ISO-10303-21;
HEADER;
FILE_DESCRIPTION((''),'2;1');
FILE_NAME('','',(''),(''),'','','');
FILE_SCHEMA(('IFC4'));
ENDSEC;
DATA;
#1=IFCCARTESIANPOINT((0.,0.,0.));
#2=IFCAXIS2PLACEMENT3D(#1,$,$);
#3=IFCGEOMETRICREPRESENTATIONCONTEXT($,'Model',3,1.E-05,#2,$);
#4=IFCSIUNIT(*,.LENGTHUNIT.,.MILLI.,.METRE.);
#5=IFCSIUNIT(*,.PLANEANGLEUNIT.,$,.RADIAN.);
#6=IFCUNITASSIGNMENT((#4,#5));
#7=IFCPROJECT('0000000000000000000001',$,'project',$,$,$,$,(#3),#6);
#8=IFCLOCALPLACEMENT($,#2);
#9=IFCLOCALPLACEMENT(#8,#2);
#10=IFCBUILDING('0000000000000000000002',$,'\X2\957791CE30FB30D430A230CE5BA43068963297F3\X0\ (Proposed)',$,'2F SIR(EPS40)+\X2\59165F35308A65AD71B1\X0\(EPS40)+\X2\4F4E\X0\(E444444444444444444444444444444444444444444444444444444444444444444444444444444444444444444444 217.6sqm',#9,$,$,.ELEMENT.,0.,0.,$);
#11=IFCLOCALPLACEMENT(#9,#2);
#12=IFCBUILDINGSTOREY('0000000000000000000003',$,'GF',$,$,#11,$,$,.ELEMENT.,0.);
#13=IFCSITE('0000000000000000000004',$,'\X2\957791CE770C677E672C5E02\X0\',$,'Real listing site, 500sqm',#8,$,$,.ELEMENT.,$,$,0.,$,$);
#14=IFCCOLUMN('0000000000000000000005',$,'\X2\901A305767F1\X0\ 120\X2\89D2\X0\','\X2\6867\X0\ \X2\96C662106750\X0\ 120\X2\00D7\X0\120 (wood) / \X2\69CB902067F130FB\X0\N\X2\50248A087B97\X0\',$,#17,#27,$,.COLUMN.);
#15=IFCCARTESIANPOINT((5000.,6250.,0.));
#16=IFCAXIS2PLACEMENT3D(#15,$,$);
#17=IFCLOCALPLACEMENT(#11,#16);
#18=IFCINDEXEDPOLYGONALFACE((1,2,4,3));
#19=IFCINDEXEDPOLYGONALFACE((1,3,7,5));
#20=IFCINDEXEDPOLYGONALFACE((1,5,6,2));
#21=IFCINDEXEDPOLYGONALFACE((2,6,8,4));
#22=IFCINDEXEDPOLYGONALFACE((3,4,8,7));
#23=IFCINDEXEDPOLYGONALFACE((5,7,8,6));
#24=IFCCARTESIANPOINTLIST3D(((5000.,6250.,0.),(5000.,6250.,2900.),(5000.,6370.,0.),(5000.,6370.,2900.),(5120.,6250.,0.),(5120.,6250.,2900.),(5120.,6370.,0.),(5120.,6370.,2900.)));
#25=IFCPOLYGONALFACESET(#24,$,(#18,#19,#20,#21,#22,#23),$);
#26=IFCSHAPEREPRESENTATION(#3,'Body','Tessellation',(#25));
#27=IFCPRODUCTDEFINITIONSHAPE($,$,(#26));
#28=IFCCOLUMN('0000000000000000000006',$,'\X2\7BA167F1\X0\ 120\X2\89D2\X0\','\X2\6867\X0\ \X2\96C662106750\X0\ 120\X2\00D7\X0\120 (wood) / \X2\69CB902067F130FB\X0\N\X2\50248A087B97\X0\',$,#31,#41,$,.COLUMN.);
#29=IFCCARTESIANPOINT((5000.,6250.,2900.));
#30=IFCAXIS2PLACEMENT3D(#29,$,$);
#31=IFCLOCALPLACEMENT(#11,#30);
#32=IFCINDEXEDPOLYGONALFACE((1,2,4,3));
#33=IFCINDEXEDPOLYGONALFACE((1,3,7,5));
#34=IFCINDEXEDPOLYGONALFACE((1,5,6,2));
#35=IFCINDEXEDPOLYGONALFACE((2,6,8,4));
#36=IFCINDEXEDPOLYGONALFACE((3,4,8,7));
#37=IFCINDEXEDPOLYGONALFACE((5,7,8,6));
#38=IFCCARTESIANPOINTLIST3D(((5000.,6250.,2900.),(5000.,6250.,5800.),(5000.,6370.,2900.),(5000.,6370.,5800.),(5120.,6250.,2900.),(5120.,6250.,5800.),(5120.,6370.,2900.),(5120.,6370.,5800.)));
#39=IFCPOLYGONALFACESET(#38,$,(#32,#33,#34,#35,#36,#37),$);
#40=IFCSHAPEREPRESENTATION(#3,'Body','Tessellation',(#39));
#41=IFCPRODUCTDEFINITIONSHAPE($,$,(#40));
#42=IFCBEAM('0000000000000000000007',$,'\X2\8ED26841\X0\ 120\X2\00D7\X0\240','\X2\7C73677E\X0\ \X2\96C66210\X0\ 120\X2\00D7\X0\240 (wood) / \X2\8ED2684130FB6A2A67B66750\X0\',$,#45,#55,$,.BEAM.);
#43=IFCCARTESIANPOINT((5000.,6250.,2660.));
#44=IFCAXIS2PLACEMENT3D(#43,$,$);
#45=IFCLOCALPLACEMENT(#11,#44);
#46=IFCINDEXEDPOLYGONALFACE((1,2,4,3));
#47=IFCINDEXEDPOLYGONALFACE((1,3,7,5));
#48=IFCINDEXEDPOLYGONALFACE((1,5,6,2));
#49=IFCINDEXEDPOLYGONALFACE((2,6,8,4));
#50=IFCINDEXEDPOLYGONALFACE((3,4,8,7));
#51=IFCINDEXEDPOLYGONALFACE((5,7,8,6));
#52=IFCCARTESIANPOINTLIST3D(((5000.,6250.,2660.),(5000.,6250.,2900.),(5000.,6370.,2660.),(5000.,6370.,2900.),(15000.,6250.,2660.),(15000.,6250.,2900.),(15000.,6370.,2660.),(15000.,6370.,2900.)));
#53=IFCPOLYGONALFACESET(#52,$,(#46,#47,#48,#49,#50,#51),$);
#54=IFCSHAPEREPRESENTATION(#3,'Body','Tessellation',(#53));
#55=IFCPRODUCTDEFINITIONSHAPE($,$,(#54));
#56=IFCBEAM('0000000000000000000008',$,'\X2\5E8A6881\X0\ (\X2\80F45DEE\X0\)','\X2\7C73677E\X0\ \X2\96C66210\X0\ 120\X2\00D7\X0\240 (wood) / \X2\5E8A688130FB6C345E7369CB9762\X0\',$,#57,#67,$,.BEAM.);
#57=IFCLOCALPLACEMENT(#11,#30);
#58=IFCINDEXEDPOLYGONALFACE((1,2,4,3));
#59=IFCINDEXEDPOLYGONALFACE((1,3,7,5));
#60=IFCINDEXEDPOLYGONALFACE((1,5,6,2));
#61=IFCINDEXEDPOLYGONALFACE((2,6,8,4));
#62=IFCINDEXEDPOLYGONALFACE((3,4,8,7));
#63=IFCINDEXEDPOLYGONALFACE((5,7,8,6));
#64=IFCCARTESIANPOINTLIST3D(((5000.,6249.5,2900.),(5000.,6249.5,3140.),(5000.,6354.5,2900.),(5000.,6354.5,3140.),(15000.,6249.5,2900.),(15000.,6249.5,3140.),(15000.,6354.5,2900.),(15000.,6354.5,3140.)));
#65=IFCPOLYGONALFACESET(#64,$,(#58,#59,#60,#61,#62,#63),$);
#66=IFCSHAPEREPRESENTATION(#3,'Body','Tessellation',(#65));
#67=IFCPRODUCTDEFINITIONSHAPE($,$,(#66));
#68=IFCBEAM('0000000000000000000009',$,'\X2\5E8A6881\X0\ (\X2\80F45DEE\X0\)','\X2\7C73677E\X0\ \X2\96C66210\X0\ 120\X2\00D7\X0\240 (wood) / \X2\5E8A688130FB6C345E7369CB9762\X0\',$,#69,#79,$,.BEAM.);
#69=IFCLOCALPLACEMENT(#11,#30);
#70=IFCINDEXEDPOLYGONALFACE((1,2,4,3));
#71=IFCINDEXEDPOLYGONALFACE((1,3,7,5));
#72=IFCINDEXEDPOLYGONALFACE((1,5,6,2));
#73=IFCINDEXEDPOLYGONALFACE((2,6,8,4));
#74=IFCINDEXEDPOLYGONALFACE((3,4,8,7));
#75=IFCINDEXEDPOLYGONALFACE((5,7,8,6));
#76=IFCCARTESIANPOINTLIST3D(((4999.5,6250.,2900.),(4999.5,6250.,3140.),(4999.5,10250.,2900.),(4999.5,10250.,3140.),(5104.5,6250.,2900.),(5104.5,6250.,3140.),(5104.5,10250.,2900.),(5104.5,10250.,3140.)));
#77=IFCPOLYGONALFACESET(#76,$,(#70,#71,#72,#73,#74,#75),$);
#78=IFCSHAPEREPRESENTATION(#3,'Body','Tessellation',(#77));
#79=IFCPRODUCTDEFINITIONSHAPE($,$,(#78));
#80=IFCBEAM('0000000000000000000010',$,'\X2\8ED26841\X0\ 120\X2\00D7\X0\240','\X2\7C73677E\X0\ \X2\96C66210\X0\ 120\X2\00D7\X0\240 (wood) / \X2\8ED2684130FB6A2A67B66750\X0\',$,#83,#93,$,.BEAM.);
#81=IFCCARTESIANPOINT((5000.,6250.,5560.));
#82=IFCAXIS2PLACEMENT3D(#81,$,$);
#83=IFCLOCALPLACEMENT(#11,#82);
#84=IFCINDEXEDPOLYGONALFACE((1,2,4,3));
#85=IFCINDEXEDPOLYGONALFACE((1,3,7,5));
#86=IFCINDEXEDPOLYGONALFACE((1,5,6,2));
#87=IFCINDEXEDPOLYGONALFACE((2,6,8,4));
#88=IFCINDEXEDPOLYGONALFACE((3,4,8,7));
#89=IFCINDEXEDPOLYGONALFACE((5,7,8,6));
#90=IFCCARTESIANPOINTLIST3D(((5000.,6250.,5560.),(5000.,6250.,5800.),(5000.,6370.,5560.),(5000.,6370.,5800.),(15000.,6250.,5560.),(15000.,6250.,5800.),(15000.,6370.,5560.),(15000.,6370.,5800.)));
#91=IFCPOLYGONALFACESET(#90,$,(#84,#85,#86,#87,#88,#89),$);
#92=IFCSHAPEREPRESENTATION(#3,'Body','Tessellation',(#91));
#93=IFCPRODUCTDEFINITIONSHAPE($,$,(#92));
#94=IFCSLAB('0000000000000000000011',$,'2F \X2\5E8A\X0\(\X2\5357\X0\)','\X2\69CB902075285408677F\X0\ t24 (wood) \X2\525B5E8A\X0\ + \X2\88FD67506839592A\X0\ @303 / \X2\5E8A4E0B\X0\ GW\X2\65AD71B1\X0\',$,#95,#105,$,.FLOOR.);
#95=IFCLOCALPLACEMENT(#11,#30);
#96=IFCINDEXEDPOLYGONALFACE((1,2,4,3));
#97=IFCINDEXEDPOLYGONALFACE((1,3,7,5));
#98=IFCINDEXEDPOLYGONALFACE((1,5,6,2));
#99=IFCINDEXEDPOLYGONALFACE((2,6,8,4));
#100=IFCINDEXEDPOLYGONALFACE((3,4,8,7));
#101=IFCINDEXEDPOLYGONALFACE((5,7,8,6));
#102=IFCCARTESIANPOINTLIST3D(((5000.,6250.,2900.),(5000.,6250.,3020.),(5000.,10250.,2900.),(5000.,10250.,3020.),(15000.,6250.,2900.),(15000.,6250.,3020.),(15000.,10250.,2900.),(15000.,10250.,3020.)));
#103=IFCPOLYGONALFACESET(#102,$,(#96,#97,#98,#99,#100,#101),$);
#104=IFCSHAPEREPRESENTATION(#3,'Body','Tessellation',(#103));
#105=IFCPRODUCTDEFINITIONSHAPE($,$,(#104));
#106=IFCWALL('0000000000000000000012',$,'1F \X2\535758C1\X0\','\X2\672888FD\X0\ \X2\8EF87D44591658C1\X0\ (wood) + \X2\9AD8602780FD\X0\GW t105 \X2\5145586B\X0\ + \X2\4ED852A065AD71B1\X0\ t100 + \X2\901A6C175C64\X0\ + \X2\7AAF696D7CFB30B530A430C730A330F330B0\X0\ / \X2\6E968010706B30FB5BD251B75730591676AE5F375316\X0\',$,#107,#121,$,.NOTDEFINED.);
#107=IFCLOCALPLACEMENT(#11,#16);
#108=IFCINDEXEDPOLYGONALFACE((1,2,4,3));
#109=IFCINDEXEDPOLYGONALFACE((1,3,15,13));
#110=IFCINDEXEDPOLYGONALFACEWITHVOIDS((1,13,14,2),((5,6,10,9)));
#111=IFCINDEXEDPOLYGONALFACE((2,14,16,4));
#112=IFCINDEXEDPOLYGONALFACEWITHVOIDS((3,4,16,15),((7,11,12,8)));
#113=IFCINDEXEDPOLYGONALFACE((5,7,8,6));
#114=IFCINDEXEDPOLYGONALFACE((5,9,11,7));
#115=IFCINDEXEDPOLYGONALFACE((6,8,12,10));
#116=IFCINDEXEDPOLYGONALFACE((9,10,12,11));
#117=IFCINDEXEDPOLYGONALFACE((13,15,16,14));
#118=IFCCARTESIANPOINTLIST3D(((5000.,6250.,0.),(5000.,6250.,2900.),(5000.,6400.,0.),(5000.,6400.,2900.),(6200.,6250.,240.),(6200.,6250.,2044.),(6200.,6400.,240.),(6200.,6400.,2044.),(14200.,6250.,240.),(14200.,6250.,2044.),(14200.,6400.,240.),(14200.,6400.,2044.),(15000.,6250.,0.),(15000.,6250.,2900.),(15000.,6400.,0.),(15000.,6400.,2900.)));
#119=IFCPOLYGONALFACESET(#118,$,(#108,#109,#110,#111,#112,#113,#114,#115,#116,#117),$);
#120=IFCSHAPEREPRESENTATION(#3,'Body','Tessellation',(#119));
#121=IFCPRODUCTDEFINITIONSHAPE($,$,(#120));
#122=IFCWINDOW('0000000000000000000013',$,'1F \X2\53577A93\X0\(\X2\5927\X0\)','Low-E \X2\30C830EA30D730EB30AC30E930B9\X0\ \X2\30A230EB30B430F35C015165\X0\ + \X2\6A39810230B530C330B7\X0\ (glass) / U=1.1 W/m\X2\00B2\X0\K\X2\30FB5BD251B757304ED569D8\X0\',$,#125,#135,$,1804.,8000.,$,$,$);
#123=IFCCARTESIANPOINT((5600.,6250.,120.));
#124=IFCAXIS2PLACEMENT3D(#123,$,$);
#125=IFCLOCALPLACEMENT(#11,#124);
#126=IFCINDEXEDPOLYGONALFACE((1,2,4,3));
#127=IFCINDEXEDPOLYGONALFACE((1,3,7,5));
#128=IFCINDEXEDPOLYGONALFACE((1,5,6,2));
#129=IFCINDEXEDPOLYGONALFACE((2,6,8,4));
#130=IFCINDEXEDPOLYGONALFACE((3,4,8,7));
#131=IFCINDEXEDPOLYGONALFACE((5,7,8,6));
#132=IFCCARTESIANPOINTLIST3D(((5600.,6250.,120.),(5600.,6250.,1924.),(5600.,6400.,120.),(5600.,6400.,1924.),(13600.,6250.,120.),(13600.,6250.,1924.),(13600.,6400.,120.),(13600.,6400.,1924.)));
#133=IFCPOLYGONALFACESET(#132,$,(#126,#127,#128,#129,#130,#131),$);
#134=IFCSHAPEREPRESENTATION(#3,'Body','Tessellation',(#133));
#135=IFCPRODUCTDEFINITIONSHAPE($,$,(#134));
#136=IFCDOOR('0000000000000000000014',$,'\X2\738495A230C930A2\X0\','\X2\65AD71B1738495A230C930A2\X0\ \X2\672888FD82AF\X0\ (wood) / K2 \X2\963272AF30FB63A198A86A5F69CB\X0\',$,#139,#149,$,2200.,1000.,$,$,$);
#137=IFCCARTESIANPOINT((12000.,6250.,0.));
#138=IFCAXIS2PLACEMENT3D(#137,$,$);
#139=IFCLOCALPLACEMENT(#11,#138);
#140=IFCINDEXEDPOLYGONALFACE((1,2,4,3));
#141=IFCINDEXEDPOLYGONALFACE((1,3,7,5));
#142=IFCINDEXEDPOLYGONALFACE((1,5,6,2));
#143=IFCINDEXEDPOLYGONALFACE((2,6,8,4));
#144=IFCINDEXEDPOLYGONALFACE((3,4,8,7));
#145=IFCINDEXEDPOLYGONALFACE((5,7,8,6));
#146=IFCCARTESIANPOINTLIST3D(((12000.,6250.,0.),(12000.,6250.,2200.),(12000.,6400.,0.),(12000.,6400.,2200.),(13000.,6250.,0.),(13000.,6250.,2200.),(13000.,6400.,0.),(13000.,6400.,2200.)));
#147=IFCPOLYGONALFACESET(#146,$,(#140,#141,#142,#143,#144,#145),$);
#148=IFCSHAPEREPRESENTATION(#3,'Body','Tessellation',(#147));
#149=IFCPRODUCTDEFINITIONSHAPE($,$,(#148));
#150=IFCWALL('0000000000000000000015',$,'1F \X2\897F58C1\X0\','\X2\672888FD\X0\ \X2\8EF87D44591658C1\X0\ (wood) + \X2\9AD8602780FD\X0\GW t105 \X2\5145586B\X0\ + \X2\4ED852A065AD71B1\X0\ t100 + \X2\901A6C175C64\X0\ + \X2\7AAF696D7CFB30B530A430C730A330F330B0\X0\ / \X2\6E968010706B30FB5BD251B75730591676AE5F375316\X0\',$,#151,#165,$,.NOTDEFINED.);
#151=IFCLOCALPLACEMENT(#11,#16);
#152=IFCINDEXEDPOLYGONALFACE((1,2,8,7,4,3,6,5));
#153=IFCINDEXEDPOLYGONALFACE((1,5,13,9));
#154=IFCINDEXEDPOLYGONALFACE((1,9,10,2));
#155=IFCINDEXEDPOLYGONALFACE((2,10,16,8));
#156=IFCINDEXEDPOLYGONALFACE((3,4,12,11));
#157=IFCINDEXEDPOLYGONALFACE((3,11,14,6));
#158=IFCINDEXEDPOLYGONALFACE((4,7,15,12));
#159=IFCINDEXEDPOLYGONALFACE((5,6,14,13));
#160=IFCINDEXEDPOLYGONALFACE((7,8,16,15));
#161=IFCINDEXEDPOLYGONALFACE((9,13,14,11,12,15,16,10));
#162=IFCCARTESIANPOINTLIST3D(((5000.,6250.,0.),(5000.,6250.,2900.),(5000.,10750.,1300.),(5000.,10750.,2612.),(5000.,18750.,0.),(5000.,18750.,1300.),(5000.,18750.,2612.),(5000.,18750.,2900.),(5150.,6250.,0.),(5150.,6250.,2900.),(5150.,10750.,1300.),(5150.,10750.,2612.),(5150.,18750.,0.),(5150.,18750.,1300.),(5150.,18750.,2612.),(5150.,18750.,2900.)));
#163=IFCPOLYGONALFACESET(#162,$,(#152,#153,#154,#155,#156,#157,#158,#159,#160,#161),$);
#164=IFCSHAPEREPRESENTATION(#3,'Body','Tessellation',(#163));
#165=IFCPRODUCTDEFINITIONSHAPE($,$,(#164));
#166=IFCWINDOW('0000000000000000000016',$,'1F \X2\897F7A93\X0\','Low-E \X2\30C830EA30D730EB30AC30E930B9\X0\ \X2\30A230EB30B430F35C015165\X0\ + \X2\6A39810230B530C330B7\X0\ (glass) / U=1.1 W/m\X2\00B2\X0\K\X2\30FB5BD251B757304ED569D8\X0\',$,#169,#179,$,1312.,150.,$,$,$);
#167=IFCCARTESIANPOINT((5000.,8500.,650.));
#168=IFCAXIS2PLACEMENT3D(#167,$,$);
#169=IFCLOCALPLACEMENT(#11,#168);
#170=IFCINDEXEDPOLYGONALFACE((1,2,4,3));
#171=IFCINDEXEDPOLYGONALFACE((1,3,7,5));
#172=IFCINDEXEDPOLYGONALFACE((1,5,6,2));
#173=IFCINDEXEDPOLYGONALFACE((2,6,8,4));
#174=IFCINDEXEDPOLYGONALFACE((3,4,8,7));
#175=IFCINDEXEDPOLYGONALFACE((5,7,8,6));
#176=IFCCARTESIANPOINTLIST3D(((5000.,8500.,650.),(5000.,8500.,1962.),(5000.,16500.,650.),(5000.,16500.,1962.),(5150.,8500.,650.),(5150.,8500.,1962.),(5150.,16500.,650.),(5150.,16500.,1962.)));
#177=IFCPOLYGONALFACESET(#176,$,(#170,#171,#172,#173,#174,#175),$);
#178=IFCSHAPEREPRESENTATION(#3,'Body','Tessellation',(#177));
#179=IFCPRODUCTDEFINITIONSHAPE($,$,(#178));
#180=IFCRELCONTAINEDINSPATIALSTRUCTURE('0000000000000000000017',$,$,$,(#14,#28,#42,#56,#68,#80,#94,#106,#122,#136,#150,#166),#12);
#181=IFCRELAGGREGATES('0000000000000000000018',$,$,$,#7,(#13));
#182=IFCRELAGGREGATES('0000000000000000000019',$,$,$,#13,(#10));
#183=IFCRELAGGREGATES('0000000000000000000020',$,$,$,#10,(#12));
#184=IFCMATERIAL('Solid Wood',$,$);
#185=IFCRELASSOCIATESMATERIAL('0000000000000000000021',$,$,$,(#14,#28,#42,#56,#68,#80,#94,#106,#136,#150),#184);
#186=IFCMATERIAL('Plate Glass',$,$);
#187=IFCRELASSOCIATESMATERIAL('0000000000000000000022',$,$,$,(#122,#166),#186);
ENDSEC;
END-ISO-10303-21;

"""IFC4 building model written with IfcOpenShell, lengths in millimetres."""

from ifc_helpers import new_model, si_unit, frame, frame_2d, origin, place, context, project, spatial, rectangle, extrude, material, element, fill, save


model = new_model("IFC4")

# Units and contexts
model_context = context("Model", 3, precision=1e-05, world=origin())
ifc_project = project(units=[si_unit("LENGTHUNIT", "METRE", prefix="MILLI"), si_unit("PLANEANGLEUNIT", "RADIAN")], contexts=[model_context])

# Site, building, storey
site_placement = place(None, origin())
site = spatial("IfcSite", under=ifc_project, at=site_placement, Name="長野県松本市", ObjectType="Real listing site, 500sqm", CompositionType="ELEMENT", RefElevation=0.0)
building_placement = place(site_placement, origin())
building = spatial("IfcBuilding", under=site, at=building_placement, Name="長野・ピアノ室と防音 (Proposed)", ObjectType="2F SIR(EPS40)+外張り断熱(EPS40)+低(E444444444444444444444444444444444444444444444444444444444444444444444444444444444444444444444 217.6sqm", CompositionType="ELEMENT", ElevationOfRefHeight=0.0, ElevationOfTerrain=0.0)
storey_placement = place(building_placement, origin())
storey = spatial("IfcBuildingStorey", under=building, at=storey_placement, Name="GF", CompositionType="ELEMENT", Elevation=0.0)

# Columns
ifc_material_1 = material(Name="Solid Wood")
column_1_placement = place(storey_placement, frame((5000.0, 6250.0, 0.0)))
element("IfcColumn", 1, at=column_1_placement, inside=storey, material=ifc_material_1, Name="通し柱 120角", Description="桧 集成材 120×120 (wood) / 構造柱・N値計算", PredefinedType="COLUMN", context=model_context, shape_type="SweptSolid", body=[
    extrude(rectangle(XDim=120.0, YDim=120.0, at=frame_2d((60.0, 60.0))), frame((5000.0, 6250.0, 0.0)), (0.0, 0.0, 1.0), 2900.0),
])
column_2_placement = place(storey_placement, frame((5000.0, 6250.0, 2900.0)))
element("IfcColumn", 2, at=column_2_placement, inside=storey, material=ifc_material_1, Name="管柱 120角", Description="桧 集成材 120×120 (wood) / 構造柱・N値計算", PredefinedType="COLUMN", context=model_context, shape_type="SweptSolid", body=[
    extrude(rectangle(XDim=120.0, YDim=120.0, at=frame_2d((60.0, 60.0))), frame((5000.0, 6250.0, 2900.0)), (0.0, 0.0, 1.0), 2900.0),
])

# Beams
beam_1_placement = place(storey_placement, frame((5000.0, 6250.0, 2660.0)))
element("IfcBeam", 3, at=beam_1_placement, inside=storey, material=ifc_material_1, Name="軒桁 120×240", Description="米松 集成 120×240 (wood) / 軒桁・横架材", PredefinedType="BEAM", context=model_context, shape_type="SweptSolid", body=[
    extrude(rectangle(XDim=10000.0, YDim=120.0, at=frame_2d((5000.0, 60.0))), frame((5000.0, 6250.0, 2660.0)), (0.0, 0.0, 1.0), 240.0),
])
beam_2_placement = place(storey_placement, frame((5000.0, 6250.0, 2900.0)))
element("IfcBeam", 4, at=beam_2_placement, inside=storey, material=ifc_material_1, Name="床梁 (胴差)", Description="米松 集成 120×240 (wood) / 床梁・水平構面", PredefinedType="BEAM", context=model_context, shape_type="SweptSolid", body=[
    extrude(rectangle(XDim=10000.0, YDim=105.0, at=frame_2d((5000.0, 52.0))), frame((5000.0, 6250.0, 2900.0)), (0.0, 0.0, 1.0), 240.0),
])
beam_3_placement = place(storey_placement, frame((5000.0, 6250.0, 2900.0)))
element("IfcBeam", 5, at=beam_3_placement, inside=storey, material=ifc_material_1, Name="床梁 (胴差)", Description="米松 集成 120×240 (wood) / 床梁・水平構面", PredefinedType="BEAM", context=model_context, shape_type="SweptSolid", body=[
    extrude(rectangle(XDim=105.0, YDim=4000.0, at=frame_2d((52.0, 2000.0))), frame((5000.0, 6250.0, 2900.0)), (0.0, 0.0, 1.0), 240.0),
])
beam_4_placement = place(storey_placement, frame((5000.0, 6250.0, 5560.0)))
element("IfcBeam", 6, at=beam_4_placement, inside=storey, material=ifc_material_1, Name="軒桁 120×240", Description="米松 集成 120×240 (wood) / 軒桁・横架材", PredefinedType="BEAM", context=model_context, shape_type="SweptSolid", body=[
    extrude(rectangle(XDim=10000.0, YDim=120.0, at=frame_2d((5000.0, 60.0))), frame((5000.0, 6250.0, 5560.0)), (0.0, 0.0, 1.0), 240.0),
])

# Slab
slab_1_placement = place(storey_placement, frame((5000.0, 6250.0, 2900.0)))
element("IfcSlab", 7, at=slab_1_placement, inside=storey, material=ifc_material_1, Name="2F 床(南)", Description="構造用合板 t24 (wood) 剛床 + 製材根太 @303 / 床下 GW断熱", PredefinedType="FLOOR", context=model_context, shape_type="SweptSolid", body=[
    extrude(rectangle(XDim=10000.0, YDim=4000.0, at=frame_2d((5000.0, 2000.0))), frame((5000.0, 6250.0, 2900.0)), (0.0, 0.0, 1.0), 120.0),
])

# Wall, openings, window, door
wall_1_placement = place(storey_placement, frame((5000.0, 6250.0, 0.0)))
wall_1 = element("IfcWall", 8, at=wall_1_placement, inside=storey, material=ifc_material_1, Name="1F 南壁", Description="木製 軸組外壁 (wood) + 高性能GW t105 充填 + 付加断熱 t100 + 通気層 + 窯業系サイディング / 準耐火・寒冷地外皮強化", PredefinedType="NOTDEFINED", context=model_context, shape_type="SweptSolid", body=[
    extrude(rectangle(XDim=10000.0, YDim=150.0, at=frame_2d((5000.0, 75.0))), frame((5000.0, 6250.0, 0.0)), (0.0, 0.0, 1.0), 2900.0),
])
opening_1_placement = place(storey_placement, frame((5600.0, 6250.0, 120.0)))
opening_1 = element("IfcOpeningElement", 9, at=opening_1_placement, cuts=wall_1, PredefinedType="NOTDEFINED", context=model_context, shape_type="SweptSolid", body=[
    extrude(rectangle(XDim=8000.0, YDim=150.0, at=frame_2d((4000.0, 75.0))), frame((5600.0, 6250.0, 120.0)), (0.0, 0.0, 1.0), 1804.0),
])
opening_2_placement = place(storey_placement, frame((12000.0, 6250.0, 0.0)))
opening_2 = element("IfcOpeningElement", 10, at=opening_2_placement, cuts=wall_1, PredefinedType="NOTDEFINED", context=model_context, shape_type="SweptSolid", body=[
    extrude(rectangle(XDim=1000.0, YDim=150.0, at=frame_2d((500.0, 75.0))), frame((12000.0, 6250.0, 0.0)), (0.0, 0.0, 1.0), 2200.0),
])
ifc_material_2 = material(Name="Plate Glass")
window_1_placement = place(storey_placement, frame((5600.0, 6250.0, 120.0)))
window_1 = element("IfcWindow", 11, at=window_1_placement, inside=storey, material=ifc_material_2, Name="1F 南窓(大)", Description="Low-E トリプルガラス アルゴン封入 + 樹脂サッシ (glass) / U=1.1 W/m²K・寒冷地仕様", OverallHeight=1804.0, OverallWidth=8000.0, context=model_context, shape_type="SweptSolid", body=[
    extrude(rectangle(XDim=8000.0, YDim=150.0, at=frame_2d((4000.0, 75.0))), frame((5600.0, 6250.0, 120.0)), (0.0, 0.0, 1.0), 1804.0),
])
fill(opening_1, window_1)
door_placement = place(storey_placement, frame((12000.0, 6250.0, 0.0)))
door = element("IfcDoor", 12, at=door_placement, inside=storey, material=ifc_material_1, Name="玄関ドア", Description="断熱玄関ドア 木製芯 (wood) / K2 防犯・採風機構", OverallHeight=2200.0, OverallWidth=1000.0, context=model_context, shape_type="SweptSolid", body=[
    extrude(rectangle(XDim=1000.0, YDim=150.0, at=frame_2d((500.0, 75.0))), frame((12000.0, 6250.0, 0.0)), (0.0, 0.0, 1.0), 2200.0),
])
fill(opening_2, door)

# Wall, opening, window
wall_2_placement = place(storey_placement, frame((5000.0, 6250.0, 0.0)))
wall_2 = element("IfcWall", 13, at=wall_2_placement, inside=storey, material=ifc_material_1, Name="1F 西壁", Description="木製 軸組外壁 (wood) + 高性能GW t105 充填 + 付加断熱 t100 + 通気層 + 窯業系サイディング / 準耐火・寒冷地外皮強化", PredefinedType="NOTDEFINED", context=model_context, shape_type="SweptSolid", body=[
    extrude(rectangle(XDim=150.0, YDim=12500.0, at=frame_2d((75.0, 6250.0))), frame((5000.0, 6250.0, 0.0)), (0.0, 0.0, 1.0), 2900.0),
])
opening_3_placement = place(storey_placement, frame((5000.0, 8500.0, 650.0)))
opening_3 = element("IfcOpeningElement", 14, at=opening_3_placement, cuts=wall_2, PredefinedType="NOTDEFINED", context=model_context, shape_type="SweptSolid", body=[
    extrude(rectangle(XDim=150.0, YDim=8000.0, at=frame_2d((75.0, 4000.0))), frame((5000.0, 8500.0, 650.0)), (0.0, 0.0, 1.0), 1312.0),
])
window_2_placement = place(storey_placement, frame((5000.0, 8500.0, 650.0)))
window_2 = element("IfcWindow", 15, at=window_2_placement, inside=storey, material=ifc_material_2, Name="1F 西窓", Description="Low-E トリプルガラス アルゴン封入 + 樹脂サッシ (glass) / U=1.1 W/m²K・寒冷地仕様", OverallHeight=1312.0, OverallWidth=150.0, context=model_context, shape_type="SweptSolid", body=[
    extrude(rectangle(XDim=150.0, YDim=8000.0, at=frame_2d((75.0, 4000.0))), frame((5000.0, 8500.0, 650.0)), (0.0, 0.0, 1.0), 1312.0),
])
fill(opening_3, window_2)

save(model, "model.ifc")
